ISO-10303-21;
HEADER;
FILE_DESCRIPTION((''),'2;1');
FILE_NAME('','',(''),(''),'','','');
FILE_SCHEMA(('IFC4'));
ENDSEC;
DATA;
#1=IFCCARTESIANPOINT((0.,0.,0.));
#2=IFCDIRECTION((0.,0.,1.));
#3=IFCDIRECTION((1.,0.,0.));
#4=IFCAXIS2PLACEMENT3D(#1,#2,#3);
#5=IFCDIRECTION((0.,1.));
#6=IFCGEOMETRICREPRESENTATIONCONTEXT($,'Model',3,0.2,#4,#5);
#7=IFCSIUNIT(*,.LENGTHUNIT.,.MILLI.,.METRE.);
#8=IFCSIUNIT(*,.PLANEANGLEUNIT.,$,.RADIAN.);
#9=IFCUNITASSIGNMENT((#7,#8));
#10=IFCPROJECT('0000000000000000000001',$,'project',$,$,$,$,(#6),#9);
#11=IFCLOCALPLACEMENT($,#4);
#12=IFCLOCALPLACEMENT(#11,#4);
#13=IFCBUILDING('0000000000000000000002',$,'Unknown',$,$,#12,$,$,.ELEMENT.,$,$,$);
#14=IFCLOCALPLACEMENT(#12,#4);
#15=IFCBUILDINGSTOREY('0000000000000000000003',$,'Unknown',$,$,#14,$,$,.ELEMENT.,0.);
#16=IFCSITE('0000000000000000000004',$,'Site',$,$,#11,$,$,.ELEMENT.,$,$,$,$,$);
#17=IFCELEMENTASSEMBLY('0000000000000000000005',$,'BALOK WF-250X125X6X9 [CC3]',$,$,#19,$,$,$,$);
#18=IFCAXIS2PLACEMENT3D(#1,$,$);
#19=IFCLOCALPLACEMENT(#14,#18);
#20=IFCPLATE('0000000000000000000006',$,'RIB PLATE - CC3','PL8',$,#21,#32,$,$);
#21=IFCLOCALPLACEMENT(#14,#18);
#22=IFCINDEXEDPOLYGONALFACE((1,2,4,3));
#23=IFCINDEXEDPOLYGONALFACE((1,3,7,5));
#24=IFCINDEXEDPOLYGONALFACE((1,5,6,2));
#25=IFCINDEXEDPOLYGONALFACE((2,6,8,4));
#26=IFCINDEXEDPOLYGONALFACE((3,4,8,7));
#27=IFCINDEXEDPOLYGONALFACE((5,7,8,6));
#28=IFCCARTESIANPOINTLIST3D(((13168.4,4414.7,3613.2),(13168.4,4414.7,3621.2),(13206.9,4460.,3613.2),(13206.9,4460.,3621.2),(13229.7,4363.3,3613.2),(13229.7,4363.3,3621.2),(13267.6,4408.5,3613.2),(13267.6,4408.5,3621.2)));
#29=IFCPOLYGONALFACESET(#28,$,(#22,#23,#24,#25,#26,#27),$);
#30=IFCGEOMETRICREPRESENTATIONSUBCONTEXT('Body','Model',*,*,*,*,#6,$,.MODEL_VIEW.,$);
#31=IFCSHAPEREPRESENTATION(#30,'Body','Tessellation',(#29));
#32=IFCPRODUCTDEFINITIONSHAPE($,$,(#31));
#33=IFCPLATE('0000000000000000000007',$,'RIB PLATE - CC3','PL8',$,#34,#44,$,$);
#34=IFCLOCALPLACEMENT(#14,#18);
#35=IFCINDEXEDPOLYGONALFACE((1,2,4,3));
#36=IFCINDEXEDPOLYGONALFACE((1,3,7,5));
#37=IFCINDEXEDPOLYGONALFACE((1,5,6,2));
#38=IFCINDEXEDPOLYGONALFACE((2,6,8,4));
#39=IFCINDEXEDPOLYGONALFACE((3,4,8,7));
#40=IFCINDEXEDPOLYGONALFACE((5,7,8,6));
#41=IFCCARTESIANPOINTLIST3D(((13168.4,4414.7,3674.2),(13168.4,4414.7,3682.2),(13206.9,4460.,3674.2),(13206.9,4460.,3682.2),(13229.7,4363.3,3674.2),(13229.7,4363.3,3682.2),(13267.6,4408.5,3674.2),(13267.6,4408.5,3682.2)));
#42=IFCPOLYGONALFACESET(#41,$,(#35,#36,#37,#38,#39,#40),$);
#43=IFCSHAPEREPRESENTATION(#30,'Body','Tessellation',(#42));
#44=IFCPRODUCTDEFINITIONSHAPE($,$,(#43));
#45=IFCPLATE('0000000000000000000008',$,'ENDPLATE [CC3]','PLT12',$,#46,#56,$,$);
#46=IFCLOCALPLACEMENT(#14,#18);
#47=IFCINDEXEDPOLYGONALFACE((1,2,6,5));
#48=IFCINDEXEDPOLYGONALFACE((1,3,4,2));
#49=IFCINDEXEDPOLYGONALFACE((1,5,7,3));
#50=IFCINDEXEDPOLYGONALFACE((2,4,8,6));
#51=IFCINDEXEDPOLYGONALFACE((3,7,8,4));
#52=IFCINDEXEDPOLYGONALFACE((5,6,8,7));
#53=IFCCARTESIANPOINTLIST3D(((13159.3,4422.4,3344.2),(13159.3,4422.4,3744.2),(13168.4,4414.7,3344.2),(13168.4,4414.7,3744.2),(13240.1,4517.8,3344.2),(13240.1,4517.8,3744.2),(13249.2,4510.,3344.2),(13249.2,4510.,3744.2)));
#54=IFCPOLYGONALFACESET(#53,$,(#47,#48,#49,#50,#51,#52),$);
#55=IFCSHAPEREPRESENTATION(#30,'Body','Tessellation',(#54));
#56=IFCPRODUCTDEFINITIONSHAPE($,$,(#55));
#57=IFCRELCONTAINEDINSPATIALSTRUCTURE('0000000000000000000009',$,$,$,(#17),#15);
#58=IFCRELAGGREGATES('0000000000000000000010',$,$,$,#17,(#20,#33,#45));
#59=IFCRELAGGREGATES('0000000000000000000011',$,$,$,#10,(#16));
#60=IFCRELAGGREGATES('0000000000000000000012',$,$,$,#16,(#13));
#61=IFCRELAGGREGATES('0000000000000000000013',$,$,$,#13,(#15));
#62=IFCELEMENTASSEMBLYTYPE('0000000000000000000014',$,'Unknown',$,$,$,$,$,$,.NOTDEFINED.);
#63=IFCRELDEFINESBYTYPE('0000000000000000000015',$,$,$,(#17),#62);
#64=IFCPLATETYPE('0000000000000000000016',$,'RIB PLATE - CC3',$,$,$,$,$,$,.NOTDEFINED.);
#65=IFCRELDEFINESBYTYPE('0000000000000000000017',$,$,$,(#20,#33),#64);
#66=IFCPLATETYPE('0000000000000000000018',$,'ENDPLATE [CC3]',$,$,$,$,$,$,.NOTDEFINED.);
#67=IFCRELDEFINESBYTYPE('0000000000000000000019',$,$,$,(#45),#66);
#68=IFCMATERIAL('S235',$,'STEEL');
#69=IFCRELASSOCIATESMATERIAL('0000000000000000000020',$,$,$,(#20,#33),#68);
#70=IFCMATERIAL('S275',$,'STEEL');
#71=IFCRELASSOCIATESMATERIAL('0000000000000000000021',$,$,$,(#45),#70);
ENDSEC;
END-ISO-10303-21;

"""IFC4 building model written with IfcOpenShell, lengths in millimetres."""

from ifc_helpers import new_model, si_unit, direction, frame, origin_with_axes, place, context, subcontext, project, spatial, line, indexed_curve, outline, extrude, material, material_profile, profile_set, profile_usage, type_object, element, aggregate, save


model = new_model("IFC4")

# Units and contexts
model_context = context("Model", 3, precision=0.2, world=origin_with_axes(), true_north=direction((0.0, 1.0)))
body_context = subcontext(model_context, "Body", "Model", "MODEL_VIEW")
ifc_project = project(units=[si_unit("LENGTHUNIT", "METRE", prefix="MILLI"), si_unit("PLANEANGLEUNIT", "RADIAN")], contexts=[model_context])

# Site, building, storey
site_placement = place(None, origin_with_axes())
site = spatial("IfcSite", under=ifc_project, at=site_placement, Name="Site", CompositionType="ELEMENT")
building_placement = place(site_placement, origin_with_axes())
building = spatial("IfcBuilding", under=site, at=building_placement, Name="Unknown", CompositionType="ELEMENT")
storey_placement = place(building_placement, origin_with_axes())
storey = spatial("IfcBuildingStorey", under=building, at=storey_placement, Name="Unknown", CompositionType="ELEMENT", Elevation=0.0)

# Shared definitions
element_assembly_type = type_object("IfcElementAssemblyType", Name="Unknown", PredefinedType="NOTDEFINED")
ifc_material_1 = material(Name="S235", Category="STEEL")

# Shared definitions
ifc_material_2 = material(Name="S275", Category="STEEL")

# Element assembly, plates
assembly_1_placement = place(storey_placement, frame((13206.5, 4464.3, 3619.2), z_axis=(-0.646722, -0.762726, 0.0), x_axis=(0.762726, -0.646722, 0.0)))
assembly_1 = element("IfcElementAssembly", 1, at=assembly_1_placement, inside=storey, type_object=element_assembly_type, Name="BALOK WF-250X125X6X9 [CC3]")
ifc_material_profile_1 = material_profile(ifc_material_1, outline(indexed_curve([(0.0, 0.0), (80.0, 0.0), (80.0, 59.0), (0.4, 59.5)], segments=[line(1, 2, 3, 4, 1)])), Name="PL8")
ifc_profile_set_1 = profile_set([ifc_material_profile_1])
ifc_profile_usage_1 = profile_usage(ifc_profile_set_1, cardinal=5)
plate_type_1 = type_object("IfcPlateType", Name="RIB PLATE - CC3", PredefinedType="NOTDEFINED")
plate_1_placement = place(assembly_1_placement, frame((3.1, -2.0, 62.5), z_axis=(0.0, 1.0, 0.0), x_axis=(0.999982, 0.0, -0.006019)))
plate_1 = element("IfcPlate", 2, at=plate_1_placement, type_object=plate_type_1, material=ifc_profile_usage_1, Name="RIB PLATE - CC3", Description="PL8", context=body_context, shape_type="SolidModel", body=[
    extrude(outline(indexed_curve([(0.0, 0.0), (80.0, 0.0), (80.0, 59.0), (0.4, 59.5)], segments=[line(1, 2, 3, 4, 1)])), frame((0.0, 0.0, 4.0), z_axis=(0.0, 0.0, 1.0), x_axis=(1.0, 0.0, 0.0)), (0.0, 0.0, -1.0), 8.0),
])
plate_2_placement = place(assembly_1_placement, frame((3.1, 59.0, 62.5), z_axis=(0.0, 1.0, 0.0), x_axis=(0.999982, 0.0, -0.006019)))
plate_2 = element("IfcPlate", 3, at=plate_2_placement, type_object=plate_type_1, material=ifc_profile_usage_1, Name="RIB PLATE - CC3", Description="PL8", context=body_context, shape_type="SolidModel", body=[
    extrude(outline(indexed_curve([(0.0, 0.0), (80.0, 0.0), (80.0, 59.0), (0.4, 59.5)], segments=[line(1, 2, 3, 4, 1)])), frame((0.0, 0.0, 4.0), z_axis=(0.0, 0.0, 1.0), x_axis=(1.0, 0.0, 0.0)), (0.0, 0.0, -1.0), 8.0),
])
ifc_material_profile_2 = material_profile(ifc_material_2, outline(indexed_curve([(0.0, 0.0), (125.0, 0.0), (125.0, 400.0), (0.0, 400.0)], segments=[line(1, 2, 3, 4, 1)])), Name="PLT12")
ifc_profile_set_2 = profile_set([ifc_material_profile_2])
ifc_profile_usage_2 = profile_usage(ifc_profile_set_2, cardinal=5)
plate_type_2 = type_object("IfcPlateType", Name="ENDPLATE [CC3]", PredefinedType="NOTDEFINED")
plate_3_placement = place(assembly_1_placement, frame((-2.9, 125.0, 62.5), z_axis=(-1.0, 0.0, 0.0), x_axis=(0.0, 0.0, -1.0)))
plate_3 = element("IfcPlate", 4, at=plate_3_placement, type_object=plate_type_2, material=ifc_profile_usage_2, Name="ENDPLATE [CC3]", Description="PLT12", context=body_context, shape_type="SolidModel", body=[
    extrude(outline(indexed_curve([(0.0, 0.0), (125.0, 0.0), (125.0, 400.0), (0.0, 400.0)], segments=[line(1, 2, 3, 4, 1)])), frame((0.0, 0.0, 6.0), z_axis=(0.0, 0.0, 1.0), x_axis=(1.0, 0.0, 0.0)), (0.0, 0.0, -1.0), 12.0),
])
aggregate(assembly_1, [plate_1, plate_2, plate_3])

save(model, "model.ifc")
